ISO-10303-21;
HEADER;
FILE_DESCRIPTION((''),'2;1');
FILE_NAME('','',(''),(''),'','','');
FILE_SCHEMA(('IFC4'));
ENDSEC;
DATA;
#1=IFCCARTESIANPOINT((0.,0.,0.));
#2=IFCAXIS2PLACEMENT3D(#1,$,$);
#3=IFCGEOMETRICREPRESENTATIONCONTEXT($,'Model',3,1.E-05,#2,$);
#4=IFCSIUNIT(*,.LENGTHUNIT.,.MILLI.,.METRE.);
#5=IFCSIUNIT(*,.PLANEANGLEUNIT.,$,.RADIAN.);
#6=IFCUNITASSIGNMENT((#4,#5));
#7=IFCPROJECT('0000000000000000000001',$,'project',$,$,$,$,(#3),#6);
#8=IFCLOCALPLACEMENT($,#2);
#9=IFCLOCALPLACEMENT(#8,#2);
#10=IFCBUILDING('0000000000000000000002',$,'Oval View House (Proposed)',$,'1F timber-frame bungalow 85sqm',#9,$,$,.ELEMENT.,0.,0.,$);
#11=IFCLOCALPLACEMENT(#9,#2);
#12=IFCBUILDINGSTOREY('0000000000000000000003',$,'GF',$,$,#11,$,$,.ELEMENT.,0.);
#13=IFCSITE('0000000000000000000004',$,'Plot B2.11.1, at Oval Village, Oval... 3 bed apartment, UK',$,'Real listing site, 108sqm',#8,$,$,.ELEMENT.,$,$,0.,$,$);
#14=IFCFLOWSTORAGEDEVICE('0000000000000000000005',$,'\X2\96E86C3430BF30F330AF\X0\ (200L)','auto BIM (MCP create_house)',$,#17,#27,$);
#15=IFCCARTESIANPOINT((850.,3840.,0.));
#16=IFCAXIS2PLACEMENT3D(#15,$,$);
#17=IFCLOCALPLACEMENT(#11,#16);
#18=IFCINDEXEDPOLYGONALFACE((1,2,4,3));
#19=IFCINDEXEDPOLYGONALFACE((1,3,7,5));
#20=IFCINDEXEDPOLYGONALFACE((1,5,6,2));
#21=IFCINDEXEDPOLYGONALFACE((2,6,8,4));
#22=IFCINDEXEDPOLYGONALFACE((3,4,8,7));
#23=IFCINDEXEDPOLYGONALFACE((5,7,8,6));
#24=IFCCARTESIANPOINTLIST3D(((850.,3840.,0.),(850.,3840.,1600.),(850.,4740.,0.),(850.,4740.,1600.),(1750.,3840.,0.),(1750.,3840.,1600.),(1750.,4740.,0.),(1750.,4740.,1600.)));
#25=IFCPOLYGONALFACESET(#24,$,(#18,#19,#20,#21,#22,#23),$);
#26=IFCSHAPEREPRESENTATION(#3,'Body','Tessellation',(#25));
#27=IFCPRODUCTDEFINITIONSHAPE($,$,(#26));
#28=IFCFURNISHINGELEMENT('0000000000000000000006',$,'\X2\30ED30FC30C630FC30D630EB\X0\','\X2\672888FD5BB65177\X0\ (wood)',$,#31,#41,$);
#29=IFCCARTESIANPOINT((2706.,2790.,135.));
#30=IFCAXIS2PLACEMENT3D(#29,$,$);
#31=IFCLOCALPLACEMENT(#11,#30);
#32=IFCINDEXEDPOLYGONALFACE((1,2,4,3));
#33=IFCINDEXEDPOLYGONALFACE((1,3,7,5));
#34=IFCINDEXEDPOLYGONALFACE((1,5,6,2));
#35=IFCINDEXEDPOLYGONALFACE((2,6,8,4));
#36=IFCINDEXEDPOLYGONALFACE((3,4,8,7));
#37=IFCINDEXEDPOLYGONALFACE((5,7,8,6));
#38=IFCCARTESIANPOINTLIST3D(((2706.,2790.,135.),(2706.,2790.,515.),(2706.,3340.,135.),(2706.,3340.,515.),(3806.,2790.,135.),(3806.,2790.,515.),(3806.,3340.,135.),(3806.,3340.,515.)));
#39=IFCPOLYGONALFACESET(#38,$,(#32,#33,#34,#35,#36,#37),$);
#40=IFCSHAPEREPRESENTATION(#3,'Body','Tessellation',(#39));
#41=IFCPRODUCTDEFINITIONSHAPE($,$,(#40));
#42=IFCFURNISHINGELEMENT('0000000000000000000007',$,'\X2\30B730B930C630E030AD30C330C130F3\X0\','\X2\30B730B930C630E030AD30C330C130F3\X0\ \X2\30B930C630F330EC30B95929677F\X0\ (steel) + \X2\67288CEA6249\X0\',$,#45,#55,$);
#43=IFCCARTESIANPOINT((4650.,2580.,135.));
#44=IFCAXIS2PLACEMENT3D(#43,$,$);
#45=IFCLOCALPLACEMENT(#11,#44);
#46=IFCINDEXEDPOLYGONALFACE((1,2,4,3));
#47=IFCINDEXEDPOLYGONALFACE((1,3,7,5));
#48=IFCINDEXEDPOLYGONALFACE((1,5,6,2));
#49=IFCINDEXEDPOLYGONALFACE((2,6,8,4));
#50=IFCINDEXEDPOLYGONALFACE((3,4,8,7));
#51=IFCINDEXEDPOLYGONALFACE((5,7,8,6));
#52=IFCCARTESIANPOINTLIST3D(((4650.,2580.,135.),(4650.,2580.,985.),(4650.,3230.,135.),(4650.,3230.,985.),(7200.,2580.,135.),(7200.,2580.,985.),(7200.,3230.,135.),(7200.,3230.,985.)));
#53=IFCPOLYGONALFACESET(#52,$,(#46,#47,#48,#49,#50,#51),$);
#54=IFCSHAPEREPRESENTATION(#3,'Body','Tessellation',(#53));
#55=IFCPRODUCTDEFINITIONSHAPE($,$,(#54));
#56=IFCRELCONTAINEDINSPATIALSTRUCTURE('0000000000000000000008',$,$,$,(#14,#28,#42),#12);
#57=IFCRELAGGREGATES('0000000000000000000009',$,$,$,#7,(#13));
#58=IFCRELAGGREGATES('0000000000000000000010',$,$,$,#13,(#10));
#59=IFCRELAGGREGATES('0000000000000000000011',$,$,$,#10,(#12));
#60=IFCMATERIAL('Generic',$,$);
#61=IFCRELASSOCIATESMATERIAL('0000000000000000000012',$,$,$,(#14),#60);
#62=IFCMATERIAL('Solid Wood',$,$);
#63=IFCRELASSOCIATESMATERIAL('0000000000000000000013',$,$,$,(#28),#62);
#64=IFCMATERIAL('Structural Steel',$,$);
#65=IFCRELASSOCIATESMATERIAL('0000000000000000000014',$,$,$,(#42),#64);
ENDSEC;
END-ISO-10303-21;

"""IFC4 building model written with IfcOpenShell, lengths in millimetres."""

from ifc_helpers import new_model, si_unit, frame, frame_2d, origin, place, context, project, spatial, rectangle, extrude, material, element, save


model = new_model("IFC4")

# Units and contexts
model_context = context("Model", 3, precision=1e-05, world=origin())
ifc_project = project(units=[si_unit("LENGTHUNIT", "METRE", prefix="MILLI"), si_unit("PLANEANGLEUNIT", "RADIAN")], contexts=[model_context])

# Site, building, storey
site_placement = place(None, origin())
site = spatial("IfcSite", under=ifc_project, at=site_placement, Name="Plot B2.11.1, at Oval Village, Oval... 3 bed apartment, UK", ObjectType="Real listing site, 108sqm", CompositionType="ELEMENT", RefElevation=0.0)
building_placement = place(site_placement, origin())
building = spatial("IfcBuilding", under=site, at=building_placement, Name="Oval View House (Proposed)", ObjectType="1F timber-frame bungalow 85sqm", CompositionType="ELEMENT", ElevationOfRefHeight=0.0, ElevationOfTerrain=0.0)
storey_placement = place(building_placement, origin())
storey = spatial("IfcBuildingStorey", under=building, at=storey_placement, Name="GF", CompositionType="ELEMENT", Elevation=0.0)

# Shared definitions
ifc_material_1 = material(Name="Solid Wood")

# Shared definitions
ifc_material_2 = material(Name="Generic")

# Flow storage device
flow_storage_device_placement = place(storey_placement, frame((850.0, 3840.0, 0.0)))
element("IfcFlowStorageDevice", 1, at=flow_storage_device_placement, inside=storey, material=ifc_material_2, Name="雨水タンク (200L)", Description="auto BIM (MCP create_house)", context=model_context, shape_type="SweptSolid", body=[
    extrude(rectangle(XDim=900.0, YDim=900.0, at=frame_2d((450.0, 450.0))), frame((850.0, 3840.0, 0.0)), (0.0, 0.0, 1.0), 1600.0),
])

# Furnishing elements
furnishing_1_placement = place(storey_placement, frame((2706.0, 2790.0, 135.0)))
element("IfcFurnishingElement", 2, at=furnishing_1_placement, inside=storey, material=ifc_material_1, Name="ローテーブル", Description="木製家具 (wood)", context=model_context, shape_type="SweptSolid", body=[
    extrude(rectangle(XDim=1100.0, YDim=550.0, at=frame_2d((550.0, 275.0))), frame((2706.0, 2790.0, 135.0)), (0.0, 0.0, 1.0), 380.0),
])
ifc_material_3 = material(Name="Structural Steel")
furnishing_2_placement = place(storey_placement, frame((4650.0, 2580.0, 135.0)))
element("IfcFurnishingElement", 3, at=furnishing_2_placement, inside=storey, material=ifc_material_3, Name="システムキッチン", Description="システムキッチン ステンレス天板 (steel) + 木質扉", context=model_context, shape_type="SweptSolid", body=[
    extrude(rectangle(XDim=2550.0, YDim=650.0, at=frame_2d((1275.0, 325.0))), frame((4650.0, 2580.0, 135.0)), (0.0, 0.0, 1.0), 850.0),
])

save(model, "model.ifc")
